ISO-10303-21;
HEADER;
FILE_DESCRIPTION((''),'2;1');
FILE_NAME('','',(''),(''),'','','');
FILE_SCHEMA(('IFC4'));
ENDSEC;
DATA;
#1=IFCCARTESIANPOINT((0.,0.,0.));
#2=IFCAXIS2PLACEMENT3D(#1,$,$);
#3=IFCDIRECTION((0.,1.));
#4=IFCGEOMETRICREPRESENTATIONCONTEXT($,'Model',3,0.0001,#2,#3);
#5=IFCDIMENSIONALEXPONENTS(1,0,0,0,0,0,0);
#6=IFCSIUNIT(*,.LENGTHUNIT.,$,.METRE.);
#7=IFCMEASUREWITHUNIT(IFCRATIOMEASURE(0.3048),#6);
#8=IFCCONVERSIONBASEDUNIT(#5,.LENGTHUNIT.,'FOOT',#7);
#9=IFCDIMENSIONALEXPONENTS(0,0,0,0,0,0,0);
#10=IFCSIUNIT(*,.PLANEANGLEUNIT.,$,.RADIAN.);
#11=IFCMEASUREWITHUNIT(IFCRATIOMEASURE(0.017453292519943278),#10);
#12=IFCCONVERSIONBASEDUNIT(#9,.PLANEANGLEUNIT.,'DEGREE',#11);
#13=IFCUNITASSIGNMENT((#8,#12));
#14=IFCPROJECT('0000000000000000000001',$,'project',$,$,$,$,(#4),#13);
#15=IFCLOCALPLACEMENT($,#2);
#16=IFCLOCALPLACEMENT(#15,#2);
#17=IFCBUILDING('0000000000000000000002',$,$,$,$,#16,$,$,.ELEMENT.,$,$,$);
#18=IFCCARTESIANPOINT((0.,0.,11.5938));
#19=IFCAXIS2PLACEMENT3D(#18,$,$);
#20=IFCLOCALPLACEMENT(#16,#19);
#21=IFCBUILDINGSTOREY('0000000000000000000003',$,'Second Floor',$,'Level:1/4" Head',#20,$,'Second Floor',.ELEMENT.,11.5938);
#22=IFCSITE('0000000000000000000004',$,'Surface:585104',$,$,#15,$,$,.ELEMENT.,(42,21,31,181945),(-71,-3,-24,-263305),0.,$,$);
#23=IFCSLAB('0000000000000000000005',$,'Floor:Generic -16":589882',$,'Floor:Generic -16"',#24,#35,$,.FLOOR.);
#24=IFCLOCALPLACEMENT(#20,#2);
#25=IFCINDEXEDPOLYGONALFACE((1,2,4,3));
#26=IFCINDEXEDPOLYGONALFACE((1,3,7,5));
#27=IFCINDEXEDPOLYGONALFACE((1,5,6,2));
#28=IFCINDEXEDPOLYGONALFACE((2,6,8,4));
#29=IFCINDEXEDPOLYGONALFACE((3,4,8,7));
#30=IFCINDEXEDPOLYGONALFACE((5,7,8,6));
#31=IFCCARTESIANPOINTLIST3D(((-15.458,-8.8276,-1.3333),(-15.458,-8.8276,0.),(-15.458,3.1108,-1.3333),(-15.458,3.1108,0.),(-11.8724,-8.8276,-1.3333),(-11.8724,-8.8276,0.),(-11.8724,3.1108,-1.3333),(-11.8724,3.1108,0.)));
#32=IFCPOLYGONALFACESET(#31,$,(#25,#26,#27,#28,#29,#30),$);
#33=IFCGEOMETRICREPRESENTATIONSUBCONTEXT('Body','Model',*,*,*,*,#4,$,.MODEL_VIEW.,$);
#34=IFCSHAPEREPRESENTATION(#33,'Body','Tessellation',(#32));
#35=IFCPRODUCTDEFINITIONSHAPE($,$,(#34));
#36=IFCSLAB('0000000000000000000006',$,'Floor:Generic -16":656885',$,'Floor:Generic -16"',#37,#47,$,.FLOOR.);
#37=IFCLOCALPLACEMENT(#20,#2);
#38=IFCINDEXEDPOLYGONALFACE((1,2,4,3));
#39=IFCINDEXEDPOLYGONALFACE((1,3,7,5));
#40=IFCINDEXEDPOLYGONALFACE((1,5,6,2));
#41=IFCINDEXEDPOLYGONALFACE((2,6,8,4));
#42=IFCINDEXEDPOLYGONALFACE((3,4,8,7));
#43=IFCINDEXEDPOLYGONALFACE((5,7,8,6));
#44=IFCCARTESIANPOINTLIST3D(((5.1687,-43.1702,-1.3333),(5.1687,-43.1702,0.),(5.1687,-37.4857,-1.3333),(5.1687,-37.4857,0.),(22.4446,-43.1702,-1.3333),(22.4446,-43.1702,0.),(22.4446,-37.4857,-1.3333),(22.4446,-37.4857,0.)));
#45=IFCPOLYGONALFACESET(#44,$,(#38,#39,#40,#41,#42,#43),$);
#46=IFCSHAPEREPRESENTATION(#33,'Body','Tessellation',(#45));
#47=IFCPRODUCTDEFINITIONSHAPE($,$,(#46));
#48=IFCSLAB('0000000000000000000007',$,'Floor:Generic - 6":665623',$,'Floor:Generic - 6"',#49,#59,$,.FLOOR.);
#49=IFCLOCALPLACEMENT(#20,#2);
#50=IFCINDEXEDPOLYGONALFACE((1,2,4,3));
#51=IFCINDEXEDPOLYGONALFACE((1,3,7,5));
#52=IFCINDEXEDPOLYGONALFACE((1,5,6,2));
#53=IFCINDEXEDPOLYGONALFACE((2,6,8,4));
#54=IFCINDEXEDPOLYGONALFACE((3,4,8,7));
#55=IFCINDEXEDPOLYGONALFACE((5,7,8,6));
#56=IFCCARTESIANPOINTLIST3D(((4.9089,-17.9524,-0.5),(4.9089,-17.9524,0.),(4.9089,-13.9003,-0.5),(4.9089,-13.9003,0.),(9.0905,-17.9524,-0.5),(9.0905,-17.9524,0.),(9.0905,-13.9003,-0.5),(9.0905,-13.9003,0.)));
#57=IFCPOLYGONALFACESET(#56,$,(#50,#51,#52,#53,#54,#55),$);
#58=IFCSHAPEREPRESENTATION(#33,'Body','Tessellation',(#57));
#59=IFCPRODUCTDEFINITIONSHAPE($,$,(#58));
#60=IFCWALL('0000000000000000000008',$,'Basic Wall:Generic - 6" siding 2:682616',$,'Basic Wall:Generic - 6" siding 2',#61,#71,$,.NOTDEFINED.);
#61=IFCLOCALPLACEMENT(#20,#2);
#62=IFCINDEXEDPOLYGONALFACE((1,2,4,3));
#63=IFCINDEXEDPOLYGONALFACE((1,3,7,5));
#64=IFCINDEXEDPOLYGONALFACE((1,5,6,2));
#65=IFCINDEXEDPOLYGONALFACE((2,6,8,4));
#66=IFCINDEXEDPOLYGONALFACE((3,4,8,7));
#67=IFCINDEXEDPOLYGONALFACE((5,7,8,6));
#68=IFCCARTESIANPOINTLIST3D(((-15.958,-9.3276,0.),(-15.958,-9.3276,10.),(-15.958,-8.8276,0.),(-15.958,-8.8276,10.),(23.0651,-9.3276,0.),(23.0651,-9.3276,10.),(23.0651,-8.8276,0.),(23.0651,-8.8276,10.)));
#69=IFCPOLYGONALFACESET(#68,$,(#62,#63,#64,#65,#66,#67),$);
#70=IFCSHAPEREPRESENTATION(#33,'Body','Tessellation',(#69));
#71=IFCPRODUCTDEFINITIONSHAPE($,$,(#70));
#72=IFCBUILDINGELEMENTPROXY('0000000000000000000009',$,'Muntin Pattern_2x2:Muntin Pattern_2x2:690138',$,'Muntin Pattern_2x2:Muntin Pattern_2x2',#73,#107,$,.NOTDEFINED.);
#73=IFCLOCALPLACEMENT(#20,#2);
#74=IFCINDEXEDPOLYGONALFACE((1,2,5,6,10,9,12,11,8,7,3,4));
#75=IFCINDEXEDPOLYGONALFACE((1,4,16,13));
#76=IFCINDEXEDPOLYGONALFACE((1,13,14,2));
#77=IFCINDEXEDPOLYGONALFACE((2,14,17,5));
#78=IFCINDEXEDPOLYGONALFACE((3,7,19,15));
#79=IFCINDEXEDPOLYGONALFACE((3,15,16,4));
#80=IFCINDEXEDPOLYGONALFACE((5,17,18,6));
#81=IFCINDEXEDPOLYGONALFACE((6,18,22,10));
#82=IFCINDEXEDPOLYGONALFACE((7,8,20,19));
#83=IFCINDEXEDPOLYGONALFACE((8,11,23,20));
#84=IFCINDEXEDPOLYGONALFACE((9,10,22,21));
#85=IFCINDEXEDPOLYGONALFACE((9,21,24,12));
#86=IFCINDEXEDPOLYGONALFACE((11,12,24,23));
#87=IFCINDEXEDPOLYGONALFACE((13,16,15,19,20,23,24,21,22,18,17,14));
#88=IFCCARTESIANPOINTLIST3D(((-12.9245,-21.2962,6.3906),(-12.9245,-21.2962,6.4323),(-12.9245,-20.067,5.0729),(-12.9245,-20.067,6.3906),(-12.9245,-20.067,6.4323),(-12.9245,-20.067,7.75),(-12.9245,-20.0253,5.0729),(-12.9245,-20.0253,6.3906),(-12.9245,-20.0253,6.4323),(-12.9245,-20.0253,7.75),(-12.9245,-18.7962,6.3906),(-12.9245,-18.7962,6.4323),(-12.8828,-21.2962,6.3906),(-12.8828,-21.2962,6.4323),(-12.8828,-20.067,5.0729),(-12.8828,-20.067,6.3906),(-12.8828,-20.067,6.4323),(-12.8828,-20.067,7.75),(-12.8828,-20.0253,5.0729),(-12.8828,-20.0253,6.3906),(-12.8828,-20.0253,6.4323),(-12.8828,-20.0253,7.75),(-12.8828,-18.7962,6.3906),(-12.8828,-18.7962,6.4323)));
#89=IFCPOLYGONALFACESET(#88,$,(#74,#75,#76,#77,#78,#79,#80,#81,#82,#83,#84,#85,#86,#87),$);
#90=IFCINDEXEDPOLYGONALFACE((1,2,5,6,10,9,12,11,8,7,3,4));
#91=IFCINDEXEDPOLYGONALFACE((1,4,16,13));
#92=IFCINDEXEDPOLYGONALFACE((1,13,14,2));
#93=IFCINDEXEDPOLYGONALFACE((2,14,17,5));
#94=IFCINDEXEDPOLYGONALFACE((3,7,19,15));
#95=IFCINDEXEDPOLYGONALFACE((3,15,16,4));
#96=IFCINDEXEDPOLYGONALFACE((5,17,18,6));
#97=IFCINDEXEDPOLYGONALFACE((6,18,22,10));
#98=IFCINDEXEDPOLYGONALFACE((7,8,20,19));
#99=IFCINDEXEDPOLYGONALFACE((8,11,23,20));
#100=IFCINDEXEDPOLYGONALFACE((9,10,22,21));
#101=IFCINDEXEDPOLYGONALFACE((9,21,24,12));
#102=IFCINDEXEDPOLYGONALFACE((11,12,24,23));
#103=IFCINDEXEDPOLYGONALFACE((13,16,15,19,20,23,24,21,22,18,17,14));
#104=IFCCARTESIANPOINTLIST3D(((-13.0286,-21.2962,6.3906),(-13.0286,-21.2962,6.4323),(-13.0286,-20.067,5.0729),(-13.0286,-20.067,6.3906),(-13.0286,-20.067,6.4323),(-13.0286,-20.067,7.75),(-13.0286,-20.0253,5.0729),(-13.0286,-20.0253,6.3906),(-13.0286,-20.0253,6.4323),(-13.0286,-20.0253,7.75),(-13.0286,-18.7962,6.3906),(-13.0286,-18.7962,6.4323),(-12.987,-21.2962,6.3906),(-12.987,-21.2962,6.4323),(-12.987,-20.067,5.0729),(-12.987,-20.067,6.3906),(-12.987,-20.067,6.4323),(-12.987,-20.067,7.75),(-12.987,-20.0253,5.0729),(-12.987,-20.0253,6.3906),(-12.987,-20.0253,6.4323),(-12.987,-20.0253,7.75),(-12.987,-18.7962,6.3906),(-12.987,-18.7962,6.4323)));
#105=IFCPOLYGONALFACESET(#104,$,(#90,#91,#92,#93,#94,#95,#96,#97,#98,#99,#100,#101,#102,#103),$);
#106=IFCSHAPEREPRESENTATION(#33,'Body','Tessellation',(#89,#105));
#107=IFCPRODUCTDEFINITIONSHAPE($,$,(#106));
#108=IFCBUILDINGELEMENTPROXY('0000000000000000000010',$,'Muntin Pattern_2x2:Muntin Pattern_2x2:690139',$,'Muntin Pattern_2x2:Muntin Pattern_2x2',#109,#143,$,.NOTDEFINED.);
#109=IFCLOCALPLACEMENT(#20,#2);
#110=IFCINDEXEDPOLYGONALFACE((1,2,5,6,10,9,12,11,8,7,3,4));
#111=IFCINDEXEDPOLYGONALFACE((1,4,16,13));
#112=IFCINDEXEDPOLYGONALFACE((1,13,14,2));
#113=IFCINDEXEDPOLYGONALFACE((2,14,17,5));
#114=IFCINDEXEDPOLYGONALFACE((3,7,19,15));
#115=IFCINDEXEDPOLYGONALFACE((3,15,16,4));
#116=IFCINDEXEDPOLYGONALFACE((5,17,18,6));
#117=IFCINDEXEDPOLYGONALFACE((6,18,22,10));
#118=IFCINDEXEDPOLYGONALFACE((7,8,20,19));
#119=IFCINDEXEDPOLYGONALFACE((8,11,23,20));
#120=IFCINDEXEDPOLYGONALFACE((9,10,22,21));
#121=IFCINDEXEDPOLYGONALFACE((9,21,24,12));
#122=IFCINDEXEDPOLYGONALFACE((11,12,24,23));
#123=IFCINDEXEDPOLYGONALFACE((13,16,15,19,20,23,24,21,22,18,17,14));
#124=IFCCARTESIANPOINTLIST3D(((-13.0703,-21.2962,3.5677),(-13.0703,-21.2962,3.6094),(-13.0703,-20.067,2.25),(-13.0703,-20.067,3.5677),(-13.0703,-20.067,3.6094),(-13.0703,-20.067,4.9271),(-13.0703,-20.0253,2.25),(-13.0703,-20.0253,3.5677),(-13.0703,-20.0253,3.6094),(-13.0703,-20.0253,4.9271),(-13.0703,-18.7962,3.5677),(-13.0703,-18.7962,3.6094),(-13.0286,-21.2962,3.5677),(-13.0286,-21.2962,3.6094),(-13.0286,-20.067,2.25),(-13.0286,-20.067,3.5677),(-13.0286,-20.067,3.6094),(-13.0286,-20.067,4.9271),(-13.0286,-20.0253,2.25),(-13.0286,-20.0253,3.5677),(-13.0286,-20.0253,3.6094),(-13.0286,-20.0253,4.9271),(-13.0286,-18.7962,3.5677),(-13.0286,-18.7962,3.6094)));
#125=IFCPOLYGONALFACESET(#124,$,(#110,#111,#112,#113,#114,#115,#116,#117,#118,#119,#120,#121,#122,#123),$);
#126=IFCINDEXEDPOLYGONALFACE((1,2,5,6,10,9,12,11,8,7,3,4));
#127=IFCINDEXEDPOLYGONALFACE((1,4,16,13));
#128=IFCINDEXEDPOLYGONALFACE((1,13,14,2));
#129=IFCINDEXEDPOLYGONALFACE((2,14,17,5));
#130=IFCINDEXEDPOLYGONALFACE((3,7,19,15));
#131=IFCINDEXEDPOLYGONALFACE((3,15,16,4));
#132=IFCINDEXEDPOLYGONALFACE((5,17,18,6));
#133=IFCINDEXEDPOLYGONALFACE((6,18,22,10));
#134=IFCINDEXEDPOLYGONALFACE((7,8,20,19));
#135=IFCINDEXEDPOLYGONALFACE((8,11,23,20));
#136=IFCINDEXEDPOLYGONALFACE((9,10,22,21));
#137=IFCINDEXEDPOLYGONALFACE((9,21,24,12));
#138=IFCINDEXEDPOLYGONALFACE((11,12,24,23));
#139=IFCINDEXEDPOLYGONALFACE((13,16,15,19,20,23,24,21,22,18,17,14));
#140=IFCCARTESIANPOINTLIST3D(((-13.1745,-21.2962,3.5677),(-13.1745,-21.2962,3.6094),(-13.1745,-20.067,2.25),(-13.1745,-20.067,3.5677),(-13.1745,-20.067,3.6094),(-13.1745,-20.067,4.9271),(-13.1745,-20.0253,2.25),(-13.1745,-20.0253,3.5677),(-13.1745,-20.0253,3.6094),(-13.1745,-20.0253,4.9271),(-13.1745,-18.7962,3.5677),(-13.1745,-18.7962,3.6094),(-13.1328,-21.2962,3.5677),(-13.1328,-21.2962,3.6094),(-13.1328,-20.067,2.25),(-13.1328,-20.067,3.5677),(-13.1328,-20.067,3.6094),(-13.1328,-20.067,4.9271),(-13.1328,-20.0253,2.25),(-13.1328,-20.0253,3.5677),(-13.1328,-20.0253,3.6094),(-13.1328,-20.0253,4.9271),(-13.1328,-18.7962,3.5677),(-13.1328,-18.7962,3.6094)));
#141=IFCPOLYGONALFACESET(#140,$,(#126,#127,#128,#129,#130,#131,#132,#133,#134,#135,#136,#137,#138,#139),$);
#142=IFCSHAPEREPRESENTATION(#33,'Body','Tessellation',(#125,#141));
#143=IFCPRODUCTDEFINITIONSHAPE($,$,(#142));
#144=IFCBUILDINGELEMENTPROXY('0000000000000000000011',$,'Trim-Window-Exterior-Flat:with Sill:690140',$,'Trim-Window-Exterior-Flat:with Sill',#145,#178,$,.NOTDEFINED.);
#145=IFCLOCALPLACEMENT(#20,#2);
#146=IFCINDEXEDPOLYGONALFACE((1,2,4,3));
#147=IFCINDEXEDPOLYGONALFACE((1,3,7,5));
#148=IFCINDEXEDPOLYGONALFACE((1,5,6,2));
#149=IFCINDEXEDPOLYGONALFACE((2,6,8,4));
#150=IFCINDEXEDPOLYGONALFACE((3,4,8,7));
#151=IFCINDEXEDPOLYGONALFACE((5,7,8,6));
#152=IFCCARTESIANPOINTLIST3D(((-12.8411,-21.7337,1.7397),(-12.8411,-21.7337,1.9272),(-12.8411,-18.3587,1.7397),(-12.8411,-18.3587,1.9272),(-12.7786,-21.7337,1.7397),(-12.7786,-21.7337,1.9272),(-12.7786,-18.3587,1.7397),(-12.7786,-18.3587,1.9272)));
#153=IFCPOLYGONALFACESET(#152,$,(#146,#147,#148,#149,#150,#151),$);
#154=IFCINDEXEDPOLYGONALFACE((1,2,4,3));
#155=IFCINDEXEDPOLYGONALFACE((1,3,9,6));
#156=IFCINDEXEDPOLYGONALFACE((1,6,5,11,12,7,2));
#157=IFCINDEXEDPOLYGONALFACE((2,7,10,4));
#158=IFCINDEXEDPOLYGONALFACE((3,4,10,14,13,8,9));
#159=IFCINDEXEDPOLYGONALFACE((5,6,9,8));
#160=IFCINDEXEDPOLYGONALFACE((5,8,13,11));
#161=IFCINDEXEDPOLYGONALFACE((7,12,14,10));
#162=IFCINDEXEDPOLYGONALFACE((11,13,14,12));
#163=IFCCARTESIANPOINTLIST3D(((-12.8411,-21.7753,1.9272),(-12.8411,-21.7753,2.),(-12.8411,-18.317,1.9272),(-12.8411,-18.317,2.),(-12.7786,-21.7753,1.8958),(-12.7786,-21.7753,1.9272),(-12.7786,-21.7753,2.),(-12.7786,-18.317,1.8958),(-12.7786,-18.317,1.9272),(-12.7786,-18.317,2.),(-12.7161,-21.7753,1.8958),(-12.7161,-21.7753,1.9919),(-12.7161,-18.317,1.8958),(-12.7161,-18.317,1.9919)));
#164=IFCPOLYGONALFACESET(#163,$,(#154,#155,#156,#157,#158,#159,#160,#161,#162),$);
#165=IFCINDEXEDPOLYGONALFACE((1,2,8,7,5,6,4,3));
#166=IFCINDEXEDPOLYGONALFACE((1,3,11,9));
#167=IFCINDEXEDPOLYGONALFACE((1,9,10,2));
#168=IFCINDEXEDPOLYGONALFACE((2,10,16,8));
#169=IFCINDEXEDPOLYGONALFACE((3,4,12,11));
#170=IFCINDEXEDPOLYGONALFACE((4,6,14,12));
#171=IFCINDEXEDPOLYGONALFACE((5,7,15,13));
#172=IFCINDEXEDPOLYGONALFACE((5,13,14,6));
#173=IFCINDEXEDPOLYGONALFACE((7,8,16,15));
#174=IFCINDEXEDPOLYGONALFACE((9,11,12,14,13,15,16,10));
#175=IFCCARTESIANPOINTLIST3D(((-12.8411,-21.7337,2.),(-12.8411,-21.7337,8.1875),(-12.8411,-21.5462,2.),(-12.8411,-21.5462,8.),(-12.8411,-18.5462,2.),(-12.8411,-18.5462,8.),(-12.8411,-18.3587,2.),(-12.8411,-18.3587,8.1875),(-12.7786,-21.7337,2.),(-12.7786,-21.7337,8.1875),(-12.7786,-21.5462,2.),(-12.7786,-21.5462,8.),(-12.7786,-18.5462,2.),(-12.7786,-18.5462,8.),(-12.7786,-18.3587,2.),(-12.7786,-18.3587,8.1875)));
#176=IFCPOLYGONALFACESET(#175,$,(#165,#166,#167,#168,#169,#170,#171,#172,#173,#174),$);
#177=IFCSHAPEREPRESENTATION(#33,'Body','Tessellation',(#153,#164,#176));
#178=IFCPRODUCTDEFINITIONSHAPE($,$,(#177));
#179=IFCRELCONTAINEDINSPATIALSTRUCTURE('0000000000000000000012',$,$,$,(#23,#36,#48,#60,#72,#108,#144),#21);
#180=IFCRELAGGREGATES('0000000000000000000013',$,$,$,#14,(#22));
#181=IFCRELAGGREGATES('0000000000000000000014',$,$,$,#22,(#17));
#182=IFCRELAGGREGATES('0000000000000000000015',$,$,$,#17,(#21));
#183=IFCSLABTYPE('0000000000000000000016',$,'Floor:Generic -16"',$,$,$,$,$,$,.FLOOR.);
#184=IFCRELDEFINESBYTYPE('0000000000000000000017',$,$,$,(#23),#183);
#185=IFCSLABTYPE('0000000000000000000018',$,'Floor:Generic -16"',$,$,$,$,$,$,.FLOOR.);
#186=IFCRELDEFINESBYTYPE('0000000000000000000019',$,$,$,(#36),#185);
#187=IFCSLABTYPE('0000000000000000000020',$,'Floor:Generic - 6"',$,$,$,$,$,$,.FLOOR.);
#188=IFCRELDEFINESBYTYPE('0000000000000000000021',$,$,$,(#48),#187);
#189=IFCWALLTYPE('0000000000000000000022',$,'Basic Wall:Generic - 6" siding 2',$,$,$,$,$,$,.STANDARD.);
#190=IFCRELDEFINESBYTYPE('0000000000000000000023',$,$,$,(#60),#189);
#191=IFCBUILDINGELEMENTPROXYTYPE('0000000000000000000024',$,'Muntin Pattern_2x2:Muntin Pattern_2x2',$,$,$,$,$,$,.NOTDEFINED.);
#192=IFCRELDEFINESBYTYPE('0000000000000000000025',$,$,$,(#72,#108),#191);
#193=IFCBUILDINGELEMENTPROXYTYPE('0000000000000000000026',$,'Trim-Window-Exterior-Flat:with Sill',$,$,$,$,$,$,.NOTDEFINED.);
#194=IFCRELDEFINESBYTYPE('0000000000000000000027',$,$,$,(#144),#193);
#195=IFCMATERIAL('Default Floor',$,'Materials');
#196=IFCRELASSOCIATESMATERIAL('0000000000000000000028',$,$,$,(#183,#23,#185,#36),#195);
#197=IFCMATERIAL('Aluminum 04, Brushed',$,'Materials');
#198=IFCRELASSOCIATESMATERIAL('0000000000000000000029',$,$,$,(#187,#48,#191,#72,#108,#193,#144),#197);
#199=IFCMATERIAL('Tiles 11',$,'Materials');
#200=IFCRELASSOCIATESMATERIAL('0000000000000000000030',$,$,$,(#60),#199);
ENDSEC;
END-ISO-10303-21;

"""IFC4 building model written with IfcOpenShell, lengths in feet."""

from ifc_helpers import new_model, entity, si_unit, converted_unit, direction, frame, origin, place, context, subcontext, project, spatial, indexed_curve, outline, extrude, source, transform, mapped, material, type_object, type_shapes, element, save


model = new_model("IFC4")

# Units and contexts
model_context = context("Model", 3, precision=0.0001, world=origin(), true_north=direction((0.0, 1.0)))
body_context = subcontext(model_context, "Body", "Model", "MODEL_VIEW")
ifc_project = project(units=[converted_unit("LENGTHUNIT", "FOOT", entity("IfcRatioMeasure", 0.3048), si_unit("LENGTHUNIT", "METRE"), dimensions=[1, 0, 0, 0, 0, 0, 0]), converted_unit("PLANEANGLEUNIT", "DEGREE", entity("IfcRatioMeasure", 0.017453292519943278), si_unit("PLANEANGLEUNIT", "RADIAN"), dimensions=[0, 0, 0, 0, 0, 0, 0])], contexts=[model_context])

# Site, building, storey
site_placement = place(None, origin())
site = spatial("IfcSite", under=ifc_project, at=site_placement, Name="Surface:585104", CompositionType="ELEMENT", RefLatitude=(42, 21, 31, 181945), RefLongitude=(-71, -3, -24, -263305), RefElevation=0.0)
building_placement = place(site_placement, origin())
building = spatial("IfcBuilding", under=site, at=building_placement, CompositionType="ELEMENT")
storey_placement = place(building_placement, frame((0.0, 0.0, 11.5938)))
storey = spatial("IfcBuildingStorey", under=building, at=storey_placement, Name="Second Floor", ObjectType="Level:1/4\" Head", LongName="Second Floor", CompositionType="ELEMENT", Elevation=11.5938)

# Slabs
ifc_material_1 = material(Name="Default Floor", Category="Materials")
slab_type_1 = type_object("IfcSlabType", Name="Floor:Generic -16\"", PredefinedType="FLOOR", material=ifc_material_1)
slab_1_placement = place(storey_placement, origin())
element("IfcSlab", 1, at=slab_1_placement, inside=storey, type_object=slab_type_1, material=ifc_material_1, Name="Floor:Generic -16\":589882", ObjectType="Floor:Generic -16\"", PredefinedType="FLOOR", context=body_context, shape_type="SweptSolid", body=[
    extrude(outline(indexed_curve([(-5.9692, -1.7928), (5.9692, -1.7928), (5.9692, 1.7928), (-5.9692, 1.7928), (-5.9692, -1.7928)], self_intersect=False)), frame((-13.6652, -2.8584, 0.0), z_axis=(0.0, 0.0, -1.0), x_axis=(0.0, 1.0, 0.0)), (0.0, 0.0, 1.0), 1.3333),
])
slab_type_2 = type_object("IfcSlabType", Name="Floor:Generic -16\"", PredefinedType="FLOOR", material=ifc_material_1)
slab_2_placement = place(storey_placement, origin())
element("IfcSlab", 2, at=slab_2_placement, inside=storey, type_object=slab_type_2, material=ifc_material_1, Name="Floor:Generic -16\":656885", ObjectType="Floor:Generic -16\"", PredefinedType="FLOOR", context=body_context, shape_type="SweptSolid", body=[
    extrude(outline(indexed_curve([(-2.8423, -8.638), (2.8423, -8.638), (2.8423, 8.638), (-2.8423, 8.638), (-2.8423, -8.638)], self_intersect=False)), frame((13.8066, -40.3279, 0.0), z_axis=(0.0, 0.0, -1.0), x_axis=(0.0, 1.0, 0.0)), (0.0, 0.0, 1.0), 1.3333),
])
ifc_material_2 = material(Name="Aluminum 04, Brushed", Category="Materials")
slab_type_3 = type_object("IfcSlabType", Name="Floor:Generic - 6\"", PredefinedType="FLOOR", material=ifc_material_2)
slab_3_placement = place(storey_placement, origin())
element("IfcSlab", 3, at=slab_3_placement, inside=storey, type_object=slab_type_3, material=ifc_material_2, Name="Floor:Generic - 6\":665623", ObjectType="Floor:Generic - 6\"", PredefinedType="FLOOR", context=body_context, shape_type="SweptSolid", body=[
    extrude(outline(indexed_curve([(-2.026, -2.0908), (2.026, -2.0908), (2.026, 2.0908), (-2.026, 2.0908), (-2.026, -2.0908)], self_intersect=False)), frame((6.9997, -15.9264, 0.0), z_axis=(0.0, 0.0, -1.0), x_axis=(0.0, 1.0, 0.0)), (0.0, 0.0, 1.0), 0.5),
])

# Wall
ifc_material_3 = material(Name="Tiles 11", Category="Materials")
wall_type = type_object("IfcWallType", Name="Basic Wall:Generic - 6\" siding 2", PredefinedType="STANDARD")
wall_placement = place(storey_placement, frame((-15.958, -9.0776, 0.0)))
element("IfcWall", 4, at=wall_placement, inside=storey, type_object=wall_type, material=ifc_material_3, Name="Basic Wall:Generic - 6\" siding 2:682616", ObjectType="Basic Wall:Generic - 6\" siding 2", PredefinedType="NOTDEFINED", context=body_context, shape_type="SweptSolid", body=[
    extrude(outline(indexed_curve([(-0.25, -19.5115), (0.25, -19.5115), (0.25, 19.5115), (-0.25, 19.5115), (-0.25, -19.5115)], self_intersect=False)), frame((19.5115, 0.0, 0.0), z_axis=(0.0, 0.0, 1.0), x_axis=(0.0, 1.0, 0.0)), (0.0, 0.0, 1.0), 10.0),
])

# Building element proxies
building_element_proxy_type_1 = type_object("IfcBuildingElementProxyType", Name="Muntin Pattern_2x2:Muntin Pattern_2x2", PredefinedType="NOTDEFINED", material=ifc_material_2)
shared_shape_1 = source(origin(), body_context, "Body", "SweptSolid", [
    extrude(outline(indexed_curve([(0.0208, -0.0208), (1.3385, -0.0208), (1.3385, 0.0208), (0.0208, 0.0208), (0.0208, 1.25), (-0.0208, 1.25), (-0.0208, 0.0208), (-1.3385, 0.0208), (-1.3385, -0.0208), (-0.0208, -0.0208), (-0.0208, -1.25), (0.0208, -1.25), (0.0208, -0.0208)], self_intersect=False)), frame((0.0, -0.0729, 1.3385), z_axis=(0.0, 1.0, 0.0), x_axis=(0.0, 0.0, 1.0)), (0.0, 0.0, 1.0), 0.0417),
    extrude(outline(indexed_curve([(0.0208, -0.0208), (1.3385, -0.0208), (1.3385, 0.0208), (0.0208, 0.0208), (0.0208, 1.25), (-0.0208, 1.25), (-0.0208, 0.0208), (-1.3385, 0.0208), (-1.3385, -0.0208), (-0.0208, -0.0208), (-0.0208, -1.25), (0.0208, -1.25), (0.0208, -0.0208)], self_intersect=False)), frame((0.0, 0.0313, 1.3385), z_axis=(0.0, 1.0, 0.0), x_axis=(0.0, 0.0, 1.0)), (0.0, 0.0, 1.0), 0.0417),
])
type_shapes(building_element_proxy_type_1, [shared_shape_1])
for number, where, z_axis, x_axis, name in (
    (5, (-12.9557, -20.0462, 5.0729), (0.0, 0.0, 1.0), (0.0, 1.0, 0.0), "Muntin Pattern_2x2:Muntin Pattern_2x2:690138"),
    (6, (-13.1015, -20.0462, 2.25), (0.0, 0.0, 1.0), (0.0, 1.0, 0.0), "Muntin Pattern_2x2:Muntin Pattern_2x2:690139"),
):
    element("IfcBuildingElementProxy", number, at=place(storey_placement, frame(where, z_axis=z_axis, x_axis=x_axis)), inside=storey, type_object=building_element_proxy_type_1, material=ifc_material_2, Name=name, ObjectType="Muntin Pattern_2x2:Muntin Pattern_2x2", PredefinedType="NOTDEFINED", context=body_context, shape_type="MappedRepresentation", body=[
        mapped(shared_shape_1, transform((0.0, 0.0, 0.0), scale=1.0)),
    ])
building_element_proxy_type_2 = type_object("IfcBuildingElementProxyType", Name="Trim-Window-Exterior-Flat:with Sill", PredefinedType="NOTDEFINED", material=ifc_material_2)
shared_shape_2 = source(origin(), body_context, "Body", "SweptSolid", [
    extrude(outline(indexed_curve([(-0.0938, -1.6875), (0.0938, -1.6875), (0.0938, 1.6875), (-0.0938, 1.6875), (-0.0938, -1.6875)], self_intersect=False)), frame((0.0, 6.1665, 0.0), z_axis=(0.0, 0.0, 1.0), x_axis=(0.0, 1.0, 0.0)), (0.0, 0.0, 1.0), 0.0625),
    extrude(outline(indexed_curve([(-0.0525, -0.0625), (0.0436, -0.0625), (0.0517, 0.0), (0.0517, 0.0625), (-0.0211, 0.0625), (-0.0211, 0.0), (-0.0525, 0.0), (-0.0525, -0.0625)], self_intersect=False)), frame((-1.7292, 6.0517, 0.0625), z_axis=(1.0, 0.0, 0.0), x_axis=(0.0, -1.0, 0.0)), (0.0, 0.0, 1.0), 3.4583),
    extrude(outline(indexed_curve([(-1.6875, -3.1406), (1.6875, -3.1406), (1.6875, 3.0469), (1.5, 3.0469), (1.5, -2.9531), (-1.5, -2.9531), (-1.5, 3.0469), (-1.6875, 3.0469), (-1.6875, -3.1406)], self_intersect=False)), frame((0.0, 2.9531, 0.0)), (0.0, 0.0, 1.0), 0.0625),
])
type_shapes(building_element_proxy_type_2, [shared_shape_2])
for number, where, z_axis, x_axis, name in (
    (7, (-12.8411, -20.0462, 8.0), (1.0, 0.0, 0.0), (0.0, -1.0, 0.0), "Trim-Window-Exterior-Flat:with Sill:690140"),
):
    element("IfcBuildingElementProxy", number, at=place(storey_placement, frame(where, z_axis=z_axis, x_axis=x_axis)), inside=storey, type_object=building_element_proxy_type_2, material=ifc_material_2, Name=name, ObjectType="Trim-Window-Exterior-Flat:with Sill", PredefinedType="NOTDEFINED", context=body_context, shape_type="MappedRepresentation", body=[
        mapped(shared_shape_2, transform((0.0, 0.0, 0.0), scale=1.0)),
    ])

save(model, "model.ifc")
